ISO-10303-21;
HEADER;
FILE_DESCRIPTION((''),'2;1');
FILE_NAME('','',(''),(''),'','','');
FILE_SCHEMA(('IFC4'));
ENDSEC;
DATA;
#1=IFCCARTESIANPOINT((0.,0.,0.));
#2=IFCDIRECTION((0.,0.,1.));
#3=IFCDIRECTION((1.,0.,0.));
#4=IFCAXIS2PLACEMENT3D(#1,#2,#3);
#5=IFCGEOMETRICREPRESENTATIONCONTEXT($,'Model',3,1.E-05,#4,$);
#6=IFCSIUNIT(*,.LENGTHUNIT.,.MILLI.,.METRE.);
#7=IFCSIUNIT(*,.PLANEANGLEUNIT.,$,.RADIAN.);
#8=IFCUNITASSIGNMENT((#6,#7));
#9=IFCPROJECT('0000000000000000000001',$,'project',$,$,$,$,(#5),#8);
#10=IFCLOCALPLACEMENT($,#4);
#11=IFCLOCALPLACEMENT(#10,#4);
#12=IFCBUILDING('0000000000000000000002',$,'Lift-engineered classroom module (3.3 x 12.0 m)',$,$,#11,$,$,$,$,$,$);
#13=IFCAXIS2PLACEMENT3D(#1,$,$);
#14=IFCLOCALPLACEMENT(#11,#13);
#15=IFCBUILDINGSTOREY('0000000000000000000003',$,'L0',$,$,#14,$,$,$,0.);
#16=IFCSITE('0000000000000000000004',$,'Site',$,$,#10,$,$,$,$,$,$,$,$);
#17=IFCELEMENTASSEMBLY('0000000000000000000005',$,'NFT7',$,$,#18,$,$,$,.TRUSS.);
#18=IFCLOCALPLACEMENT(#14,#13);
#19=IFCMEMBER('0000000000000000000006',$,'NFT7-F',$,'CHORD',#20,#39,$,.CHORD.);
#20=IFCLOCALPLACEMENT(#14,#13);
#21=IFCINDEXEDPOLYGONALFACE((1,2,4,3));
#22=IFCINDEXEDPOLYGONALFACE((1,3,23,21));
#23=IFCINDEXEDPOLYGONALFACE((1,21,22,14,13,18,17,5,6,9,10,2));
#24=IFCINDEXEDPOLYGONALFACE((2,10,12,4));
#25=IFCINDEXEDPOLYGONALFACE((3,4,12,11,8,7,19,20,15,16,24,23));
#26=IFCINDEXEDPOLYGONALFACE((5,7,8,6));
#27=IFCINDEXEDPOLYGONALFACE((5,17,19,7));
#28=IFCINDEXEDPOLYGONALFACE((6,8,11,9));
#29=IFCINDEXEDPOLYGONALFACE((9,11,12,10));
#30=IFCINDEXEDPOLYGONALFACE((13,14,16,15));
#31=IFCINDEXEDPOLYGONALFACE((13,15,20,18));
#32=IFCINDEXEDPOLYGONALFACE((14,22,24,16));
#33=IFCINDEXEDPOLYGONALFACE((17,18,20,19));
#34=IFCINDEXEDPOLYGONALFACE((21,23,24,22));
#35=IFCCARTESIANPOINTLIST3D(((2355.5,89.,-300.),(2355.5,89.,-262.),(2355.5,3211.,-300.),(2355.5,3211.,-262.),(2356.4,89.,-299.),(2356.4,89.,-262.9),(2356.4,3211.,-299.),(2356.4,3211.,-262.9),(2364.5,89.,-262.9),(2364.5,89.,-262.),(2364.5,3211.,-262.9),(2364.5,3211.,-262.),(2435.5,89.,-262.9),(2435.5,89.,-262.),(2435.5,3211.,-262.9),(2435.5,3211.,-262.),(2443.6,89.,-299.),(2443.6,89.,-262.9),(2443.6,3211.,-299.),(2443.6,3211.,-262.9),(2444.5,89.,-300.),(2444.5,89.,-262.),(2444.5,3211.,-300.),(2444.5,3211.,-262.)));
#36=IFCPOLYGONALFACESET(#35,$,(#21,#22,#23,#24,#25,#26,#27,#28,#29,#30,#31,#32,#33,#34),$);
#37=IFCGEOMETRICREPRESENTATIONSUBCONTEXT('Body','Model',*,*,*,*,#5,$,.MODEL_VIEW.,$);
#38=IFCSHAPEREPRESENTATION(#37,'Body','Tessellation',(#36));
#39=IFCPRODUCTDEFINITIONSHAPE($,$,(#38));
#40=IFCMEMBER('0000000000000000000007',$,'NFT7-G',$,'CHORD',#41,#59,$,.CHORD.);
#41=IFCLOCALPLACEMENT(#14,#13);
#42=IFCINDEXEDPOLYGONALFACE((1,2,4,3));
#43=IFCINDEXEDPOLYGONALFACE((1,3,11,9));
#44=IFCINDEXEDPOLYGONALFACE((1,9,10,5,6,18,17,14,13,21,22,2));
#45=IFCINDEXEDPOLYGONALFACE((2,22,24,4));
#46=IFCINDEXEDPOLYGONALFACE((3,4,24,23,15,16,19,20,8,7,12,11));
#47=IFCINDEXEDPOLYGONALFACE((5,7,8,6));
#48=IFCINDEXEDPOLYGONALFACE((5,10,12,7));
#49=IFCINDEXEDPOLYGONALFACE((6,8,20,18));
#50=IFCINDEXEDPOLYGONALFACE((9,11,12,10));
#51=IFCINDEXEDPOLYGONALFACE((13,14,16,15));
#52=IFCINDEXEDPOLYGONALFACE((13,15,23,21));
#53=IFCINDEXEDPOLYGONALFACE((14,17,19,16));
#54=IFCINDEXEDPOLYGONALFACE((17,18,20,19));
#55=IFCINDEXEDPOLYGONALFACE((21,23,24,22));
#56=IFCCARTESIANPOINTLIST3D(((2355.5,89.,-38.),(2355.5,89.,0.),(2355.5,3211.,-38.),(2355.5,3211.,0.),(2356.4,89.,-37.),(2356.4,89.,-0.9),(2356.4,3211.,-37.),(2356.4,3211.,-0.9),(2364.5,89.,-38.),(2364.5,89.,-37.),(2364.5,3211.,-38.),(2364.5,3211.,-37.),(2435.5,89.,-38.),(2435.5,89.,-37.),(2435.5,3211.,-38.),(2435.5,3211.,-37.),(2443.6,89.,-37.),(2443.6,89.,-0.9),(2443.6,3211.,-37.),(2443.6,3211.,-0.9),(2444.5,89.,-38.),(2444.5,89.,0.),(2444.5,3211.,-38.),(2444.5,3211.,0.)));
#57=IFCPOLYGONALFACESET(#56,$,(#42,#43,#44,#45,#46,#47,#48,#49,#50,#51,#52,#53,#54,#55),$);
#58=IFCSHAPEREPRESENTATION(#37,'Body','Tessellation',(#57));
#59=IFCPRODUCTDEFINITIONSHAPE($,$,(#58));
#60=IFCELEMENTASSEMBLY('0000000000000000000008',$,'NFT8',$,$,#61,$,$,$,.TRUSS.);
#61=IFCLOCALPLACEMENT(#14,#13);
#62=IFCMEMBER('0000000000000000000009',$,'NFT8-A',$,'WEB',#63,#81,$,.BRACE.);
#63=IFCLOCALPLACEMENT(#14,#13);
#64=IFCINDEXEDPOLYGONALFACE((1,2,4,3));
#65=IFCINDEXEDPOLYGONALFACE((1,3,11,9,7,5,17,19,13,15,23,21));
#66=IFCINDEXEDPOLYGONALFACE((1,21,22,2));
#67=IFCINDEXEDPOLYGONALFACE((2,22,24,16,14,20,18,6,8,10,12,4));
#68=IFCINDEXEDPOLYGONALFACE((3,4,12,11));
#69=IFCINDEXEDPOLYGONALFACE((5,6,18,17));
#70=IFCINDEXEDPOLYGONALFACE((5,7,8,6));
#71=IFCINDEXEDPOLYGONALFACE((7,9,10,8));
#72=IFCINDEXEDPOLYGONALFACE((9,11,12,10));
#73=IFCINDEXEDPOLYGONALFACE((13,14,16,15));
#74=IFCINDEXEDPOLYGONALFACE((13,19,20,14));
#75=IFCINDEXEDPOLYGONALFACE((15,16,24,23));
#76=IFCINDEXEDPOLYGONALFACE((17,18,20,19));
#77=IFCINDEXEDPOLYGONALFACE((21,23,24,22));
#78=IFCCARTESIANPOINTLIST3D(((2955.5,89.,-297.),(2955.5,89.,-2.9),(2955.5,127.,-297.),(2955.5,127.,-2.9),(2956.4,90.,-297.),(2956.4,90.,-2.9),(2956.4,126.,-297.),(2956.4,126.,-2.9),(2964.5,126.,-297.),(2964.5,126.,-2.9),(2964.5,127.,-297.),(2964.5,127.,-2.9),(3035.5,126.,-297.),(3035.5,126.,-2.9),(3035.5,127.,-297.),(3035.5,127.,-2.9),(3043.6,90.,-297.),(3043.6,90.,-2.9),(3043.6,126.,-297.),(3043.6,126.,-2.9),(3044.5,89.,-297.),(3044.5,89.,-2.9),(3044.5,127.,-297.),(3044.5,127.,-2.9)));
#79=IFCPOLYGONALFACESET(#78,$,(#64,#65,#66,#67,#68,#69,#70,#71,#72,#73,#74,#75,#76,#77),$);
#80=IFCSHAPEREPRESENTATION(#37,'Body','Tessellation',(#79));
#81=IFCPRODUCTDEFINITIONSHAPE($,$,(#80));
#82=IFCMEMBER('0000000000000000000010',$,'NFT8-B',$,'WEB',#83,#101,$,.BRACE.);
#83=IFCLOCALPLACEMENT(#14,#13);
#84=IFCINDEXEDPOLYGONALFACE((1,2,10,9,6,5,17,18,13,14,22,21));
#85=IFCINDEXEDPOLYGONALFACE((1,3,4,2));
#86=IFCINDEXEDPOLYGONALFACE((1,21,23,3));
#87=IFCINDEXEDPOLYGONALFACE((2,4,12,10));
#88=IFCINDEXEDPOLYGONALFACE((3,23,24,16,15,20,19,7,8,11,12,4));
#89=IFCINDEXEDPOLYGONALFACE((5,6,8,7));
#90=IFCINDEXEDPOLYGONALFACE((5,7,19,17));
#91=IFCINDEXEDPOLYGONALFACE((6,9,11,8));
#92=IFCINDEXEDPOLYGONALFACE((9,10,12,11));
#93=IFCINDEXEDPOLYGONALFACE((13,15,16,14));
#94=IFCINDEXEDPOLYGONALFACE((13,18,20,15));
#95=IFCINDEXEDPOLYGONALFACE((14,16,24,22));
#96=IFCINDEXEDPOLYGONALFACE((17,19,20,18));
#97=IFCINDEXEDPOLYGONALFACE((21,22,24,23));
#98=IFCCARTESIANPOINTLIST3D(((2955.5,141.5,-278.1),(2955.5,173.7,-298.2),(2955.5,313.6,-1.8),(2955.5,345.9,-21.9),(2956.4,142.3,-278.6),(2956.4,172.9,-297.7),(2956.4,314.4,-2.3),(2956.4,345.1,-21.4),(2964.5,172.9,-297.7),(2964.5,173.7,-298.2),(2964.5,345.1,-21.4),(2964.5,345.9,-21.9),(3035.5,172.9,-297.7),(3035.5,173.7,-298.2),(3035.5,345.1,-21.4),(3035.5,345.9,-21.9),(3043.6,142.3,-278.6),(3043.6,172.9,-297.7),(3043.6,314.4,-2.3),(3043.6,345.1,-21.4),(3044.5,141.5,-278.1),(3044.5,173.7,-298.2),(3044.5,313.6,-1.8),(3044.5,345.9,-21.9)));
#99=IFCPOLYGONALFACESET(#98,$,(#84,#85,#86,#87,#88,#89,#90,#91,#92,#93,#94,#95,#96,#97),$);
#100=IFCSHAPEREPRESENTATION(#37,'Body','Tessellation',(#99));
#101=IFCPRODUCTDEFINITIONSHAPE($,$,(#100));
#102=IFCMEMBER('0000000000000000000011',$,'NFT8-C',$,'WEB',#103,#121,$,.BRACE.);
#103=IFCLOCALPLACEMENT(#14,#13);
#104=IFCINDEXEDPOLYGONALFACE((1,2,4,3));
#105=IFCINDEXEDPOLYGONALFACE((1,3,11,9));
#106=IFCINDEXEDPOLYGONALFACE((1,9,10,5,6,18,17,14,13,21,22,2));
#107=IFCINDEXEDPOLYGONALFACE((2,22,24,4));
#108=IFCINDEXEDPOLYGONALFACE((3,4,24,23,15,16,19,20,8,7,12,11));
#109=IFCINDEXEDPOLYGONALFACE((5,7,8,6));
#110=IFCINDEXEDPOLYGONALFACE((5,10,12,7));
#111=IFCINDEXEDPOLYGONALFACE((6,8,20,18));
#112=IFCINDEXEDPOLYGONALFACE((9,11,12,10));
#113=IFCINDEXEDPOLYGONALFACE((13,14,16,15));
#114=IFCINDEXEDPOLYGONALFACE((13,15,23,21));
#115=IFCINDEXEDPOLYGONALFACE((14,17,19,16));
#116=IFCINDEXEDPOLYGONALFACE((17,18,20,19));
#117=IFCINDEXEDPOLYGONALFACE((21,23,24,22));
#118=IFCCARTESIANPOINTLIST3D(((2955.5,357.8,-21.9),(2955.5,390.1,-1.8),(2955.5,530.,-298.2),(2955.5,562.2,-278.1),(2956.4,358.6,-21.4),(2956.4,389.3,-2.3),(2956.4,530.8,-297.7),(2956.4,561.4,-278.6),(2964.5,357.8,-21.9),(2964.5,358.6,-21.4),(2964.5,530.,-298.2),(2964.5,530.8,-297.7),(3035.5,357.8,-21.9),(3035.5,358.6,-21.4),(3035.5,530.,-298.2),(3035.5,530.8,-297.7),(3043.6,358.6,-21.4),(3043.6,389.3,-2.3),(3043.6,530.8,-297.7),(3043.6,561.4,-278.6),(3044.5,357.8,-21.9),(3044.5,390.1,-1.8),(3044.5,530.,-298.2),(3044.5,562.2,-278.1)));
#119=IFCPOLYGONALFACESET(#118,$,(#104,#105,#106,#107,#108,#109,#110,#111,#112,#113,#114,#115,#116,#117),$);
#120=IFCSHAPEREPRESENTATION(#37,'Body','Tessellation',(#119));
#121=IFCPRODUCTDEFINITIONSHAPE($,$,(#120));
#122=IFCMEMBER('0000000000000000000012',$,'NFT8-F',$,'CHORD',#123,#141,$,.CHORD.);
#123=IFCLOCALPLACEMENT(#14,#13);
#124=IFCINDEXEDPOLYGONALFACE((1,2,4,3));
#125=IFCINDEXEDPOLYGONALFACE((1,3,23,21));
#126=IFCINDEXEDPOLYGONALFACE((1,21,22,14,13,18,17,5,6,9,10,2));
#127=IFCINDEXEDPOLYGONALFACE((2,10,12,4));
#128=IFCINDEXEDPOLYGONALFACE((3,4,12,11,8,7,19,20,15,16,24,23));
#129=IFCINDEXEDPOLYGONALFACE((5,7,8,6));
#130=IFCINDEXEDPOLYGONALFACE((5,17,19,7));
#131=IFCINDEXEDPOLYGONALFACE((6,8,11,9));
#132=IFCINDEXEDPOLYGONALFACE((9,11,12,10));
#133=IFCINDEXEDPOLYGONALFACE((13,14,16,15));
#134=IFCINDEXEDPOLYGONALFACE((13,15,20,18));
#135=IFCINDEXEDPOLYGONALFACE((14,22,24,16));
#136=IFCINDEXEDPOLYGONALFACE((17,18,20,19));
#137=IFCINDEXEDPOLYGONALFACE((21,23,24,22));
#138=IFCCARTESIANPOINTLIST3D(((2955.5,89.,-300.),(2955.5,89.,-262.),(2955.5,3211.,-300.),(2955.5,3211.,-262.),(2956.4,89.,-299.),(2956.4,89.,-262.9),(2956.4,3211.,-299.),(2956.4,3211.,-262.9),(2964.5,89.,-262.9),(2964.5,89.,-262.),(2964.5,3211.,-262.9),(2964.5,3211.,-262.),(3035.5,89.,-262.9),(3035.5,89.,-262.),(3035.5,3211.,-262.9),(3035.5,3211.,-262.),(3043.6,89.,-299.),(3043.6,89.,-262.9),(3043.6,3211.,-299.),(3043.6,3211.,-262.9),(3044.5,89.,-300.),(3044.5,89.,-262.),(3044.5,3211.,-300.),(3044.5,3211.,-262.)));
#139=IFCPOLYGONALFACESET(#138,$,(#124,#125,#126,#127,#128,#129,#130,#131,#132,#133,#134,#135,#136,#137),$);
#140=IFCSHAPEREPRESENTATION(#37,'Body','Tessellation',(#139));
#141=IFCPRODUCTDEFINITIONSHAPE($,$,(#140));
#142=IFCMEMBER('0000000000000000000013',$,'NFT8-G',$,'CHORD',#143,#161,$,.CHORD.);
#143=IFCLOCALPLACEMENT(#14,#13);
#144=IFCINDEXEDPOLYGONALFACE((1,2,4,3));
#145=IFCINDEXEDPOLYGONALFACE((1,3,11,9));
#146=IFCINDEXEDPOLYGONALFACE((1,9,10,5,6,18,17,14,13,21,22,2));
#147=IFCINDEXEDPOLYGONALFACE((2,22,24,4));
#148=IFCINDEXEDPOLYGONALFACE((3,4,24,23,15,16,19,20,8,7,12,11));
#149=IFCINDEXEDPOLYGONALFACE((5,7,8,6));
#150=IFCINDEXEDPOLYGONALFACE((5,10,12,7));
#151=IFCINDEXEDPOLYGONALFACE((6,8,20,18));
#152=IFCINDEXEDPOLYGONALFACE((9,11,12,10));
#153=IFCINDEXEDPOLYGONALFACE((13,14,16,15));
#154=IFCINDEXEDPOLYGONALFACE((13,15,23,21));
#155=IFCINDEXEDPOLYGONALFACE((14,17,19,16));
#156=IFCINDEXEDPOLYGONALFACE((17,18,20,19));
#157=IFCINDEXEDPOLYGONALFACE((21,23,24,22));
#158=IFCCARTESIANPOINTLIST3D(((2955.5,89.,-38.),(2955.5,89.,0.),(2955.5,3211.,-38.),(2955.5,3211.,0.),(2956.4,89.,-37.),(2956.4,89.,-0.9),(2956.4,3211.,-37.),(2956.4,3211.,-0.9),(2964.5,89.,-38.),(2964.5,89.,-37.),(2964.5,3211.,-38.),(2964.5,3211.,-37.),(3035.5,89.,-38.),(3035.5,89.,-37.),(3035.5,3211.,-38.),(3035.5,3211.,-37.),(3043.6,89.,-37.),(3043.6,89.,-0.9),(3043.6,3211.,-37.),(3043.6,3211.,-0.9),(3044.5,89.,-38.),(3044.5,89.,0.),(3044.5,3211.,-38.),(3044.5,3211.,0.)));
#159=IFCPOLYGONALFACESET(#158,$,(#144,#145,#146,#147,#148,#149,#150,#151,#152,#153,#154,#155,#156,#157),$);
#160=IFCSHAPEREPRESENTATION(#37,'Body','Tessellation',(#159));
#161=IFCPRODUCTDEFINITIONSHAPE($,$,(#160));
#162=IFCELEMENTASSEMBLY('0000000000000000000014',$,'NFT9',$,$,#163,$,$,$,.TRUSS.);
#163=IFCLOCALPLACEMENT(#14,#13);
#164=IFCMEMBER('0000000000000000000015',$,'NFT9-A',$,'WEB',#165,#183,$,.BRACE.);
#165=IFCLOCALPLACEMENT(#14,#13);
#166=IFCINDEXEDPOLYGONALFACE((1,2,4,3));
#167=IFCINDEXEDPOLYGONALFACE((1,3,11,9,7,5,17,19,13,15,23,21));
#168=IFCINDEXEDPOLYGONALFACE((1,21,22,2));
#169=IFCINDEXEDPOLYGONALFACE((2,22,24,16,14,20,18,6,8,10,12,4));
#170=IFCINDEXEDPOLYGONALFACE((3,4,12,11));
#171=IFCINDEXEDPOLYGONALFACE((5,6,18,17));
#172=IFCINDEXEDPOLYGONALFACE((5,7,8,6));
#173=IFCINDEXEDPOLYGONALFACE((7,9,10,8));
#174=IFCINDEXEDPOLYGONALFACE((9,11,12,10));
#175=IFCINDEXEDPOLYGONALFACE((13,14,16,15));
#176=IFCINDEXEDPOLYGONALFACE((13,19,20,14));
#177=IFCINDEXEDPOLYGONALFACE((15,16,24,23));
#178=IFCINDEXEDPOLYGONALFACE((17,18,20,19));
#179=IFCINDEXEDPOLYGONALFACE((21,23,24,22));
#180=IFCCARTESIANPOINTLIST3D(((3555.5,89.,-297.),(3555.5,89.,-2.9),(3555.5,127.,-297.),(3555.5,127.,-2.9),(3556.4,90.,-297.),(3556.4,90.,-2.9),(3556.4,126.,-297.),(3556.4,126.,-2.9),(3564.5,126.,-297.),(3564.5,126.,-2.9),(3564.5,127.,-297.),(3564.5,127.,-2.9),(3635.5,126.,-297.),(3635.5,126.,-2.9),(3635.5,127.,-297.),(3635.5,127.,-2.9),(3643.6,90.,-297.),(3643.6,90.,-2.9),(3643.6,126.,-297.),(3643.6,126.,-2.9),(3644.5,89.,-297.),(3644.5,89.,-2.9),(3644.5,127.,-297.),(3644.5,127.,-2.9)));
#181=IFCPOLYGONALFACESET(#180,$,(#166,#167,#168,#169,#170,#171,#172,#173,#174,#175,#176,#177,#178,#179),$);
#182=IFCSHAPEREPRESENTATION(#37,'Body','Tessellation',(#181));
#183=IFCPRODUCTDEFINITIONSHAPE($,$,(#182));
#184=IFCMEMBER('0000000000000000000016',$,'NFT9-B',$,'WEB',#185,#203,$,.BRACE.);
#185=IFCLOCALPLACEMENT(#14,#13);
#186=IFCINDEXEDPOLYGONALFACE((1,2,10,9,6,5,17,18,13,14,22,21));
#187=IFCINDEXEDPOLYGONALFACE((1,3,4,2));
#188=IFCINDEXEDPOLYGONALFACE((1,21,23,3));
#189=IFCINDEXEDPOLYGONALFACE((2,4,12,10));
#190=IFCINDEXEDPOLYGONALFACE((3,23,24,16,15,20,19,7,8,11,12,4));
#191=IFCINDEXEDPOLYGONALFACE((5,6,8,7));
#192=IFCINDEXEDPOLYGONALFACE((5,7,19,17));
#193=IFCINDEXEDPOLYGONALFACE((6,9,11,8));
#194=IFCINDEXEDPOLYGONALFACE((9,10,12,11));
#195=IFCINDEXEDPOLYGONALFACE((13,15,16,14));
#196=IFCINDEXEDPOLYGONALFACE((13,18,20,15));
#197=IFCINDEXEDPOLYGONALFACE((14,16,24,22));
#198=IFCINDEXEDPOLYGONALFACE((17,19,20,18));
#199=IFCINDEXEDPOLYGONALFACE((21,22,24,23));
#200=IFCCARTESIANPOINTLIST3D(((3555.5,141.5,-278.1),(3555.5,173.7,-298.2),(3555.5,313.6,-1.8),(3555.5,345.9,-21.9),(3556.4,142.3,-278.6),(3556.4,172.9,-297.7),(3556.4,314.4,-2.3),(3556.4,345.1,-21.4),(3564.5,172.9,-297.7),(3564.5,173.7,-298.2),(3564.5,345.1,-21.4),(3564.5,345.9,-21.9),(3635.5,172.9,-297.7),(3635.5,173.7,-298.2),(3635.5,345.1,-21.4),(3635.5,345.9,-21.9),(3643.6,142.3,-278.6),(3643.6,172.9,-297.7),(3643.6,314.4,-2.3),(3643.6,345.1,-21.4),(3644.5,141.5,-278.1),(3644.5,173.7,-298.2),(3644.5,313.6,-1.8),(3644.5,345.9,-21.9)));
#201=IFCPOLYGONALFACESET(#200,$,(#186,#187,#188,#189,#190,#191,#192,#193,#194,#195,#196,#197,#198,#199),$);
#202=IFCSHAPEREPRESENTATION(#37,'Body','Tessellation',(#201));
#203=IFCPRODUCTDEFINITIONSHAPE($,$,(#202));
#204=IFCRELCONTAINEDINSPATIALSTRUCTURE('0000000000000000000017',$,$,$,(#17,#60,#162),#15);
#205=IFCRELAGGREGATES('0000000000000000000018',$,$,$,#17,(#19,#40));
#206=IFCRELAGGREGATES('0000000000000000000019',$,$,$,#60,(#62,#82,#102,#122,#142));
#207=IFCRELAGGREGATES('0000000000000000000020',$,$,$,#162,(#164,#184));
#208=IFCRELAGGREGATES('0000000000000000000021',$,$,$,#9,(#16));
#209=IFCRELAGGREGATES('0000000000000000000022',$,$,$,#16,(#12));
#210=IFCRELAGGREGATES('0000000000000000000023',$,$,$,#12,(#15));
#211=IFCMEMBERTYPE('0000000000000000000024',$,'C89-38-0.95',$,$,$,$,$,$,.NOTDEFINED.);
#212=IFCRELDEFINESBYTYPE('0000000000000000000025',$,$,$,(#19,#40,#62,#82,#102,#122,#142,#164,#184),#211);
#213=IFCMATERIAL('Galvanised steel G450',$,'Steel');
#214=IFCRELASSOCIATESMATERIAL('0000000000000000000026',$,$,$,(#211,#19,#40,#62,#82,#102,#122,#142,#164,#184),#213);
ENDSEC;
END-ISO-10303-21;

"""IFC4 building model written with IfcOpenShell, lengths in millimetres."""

from ifc_helpers import new_model, si_unit, frame, origin, origin_with_axes, origin_2d, place, context, subcontext, project, spatial, c_section, extrude, material, material_profile, profile_set, profile_usage, type_object, element, aggregate, save


model = new_model("IFC4")

# Units and contexts
model_context = context("Model", 3, precision=1e-05, world=origin_with_axes())
body_context = subcontext(model_context, "Body", "Model", "MODEL_VIEW")
ifc_project = project(units=[si_unit("LENGTHUNIT", "METRE", prefix="MILLI"), si_unit("PLANEANGLEUNIT", "RADIAN")], contexts=[model_context])

# Site, building, storey
site_placement = place(None, origin_with_axes())
site = spatial("IfcSite", under=ifc_project, at=site_placement, Name="Site")
building_placement = place(site_placement, origin_with_axes())
building = spatial("IfcBuilding", under=site, at=building_placement, Name="Lift-engineered classroom module (3.3 x 12.0 m)")
storey_placement = place(building_placement, origin())
storey = spatial("IfcBuildingStorey", under=building, at=storey_placement, Name="L0", Elevation=0.0)

# Element assemblies, members
assembly_1_placement = place(storey_placement, frame((2400.0, 89.0, -300.0)))
assembly_1 = element("IfcElementAssembly", 1, at=assembly_1_placement, inside=storey, Name="NFT7", PredefinedType="TRUSS")
ifc_material = material(Name="Galvanised steel G450", Category="Steel")
ifc_material_profile_1 = material_profile(ifc_material, c_section(Depth=89.0, Width=38.0, WallThickness=0.9, Girth=9.0, at=origin_2d()), Name="C89-38-0.95")
ifc_profile_set_1 = profile_set([ifc_material_profile_1], Name="C89-38-0.95")
ifc_profile_usage_1 = profile_usage(ifc_profile_set_1)
member_type_1 = type_object("IfcMemberType", Name="C89-38-0.95", PredefinedType="NOTDEFINED", material=ifc_profile_set_1)
member_1_placement = place(assembly_1_placement, frame((0.0, 0.0, 19.0), z_axis=(0.0, 1.0, 0.0), x_axis=(0.0, 0.0, 1.0)))
member_1 = element("IfcMember", 2, at=member_1_placement, type_object=member_type_1, material=ifc_profile_usage_1, Name="NFT7-F", ObjectType="CHORD", PredefinedType="CHORD", context=body_context, shape_type="SweptSolid", body=[
    extrude(c_section(Depth=89.0, Width=38.0, WallThickness=0.9, Girth=9.0, at=origin_2d()), origin(), (0.0, 0.0, 1.0), 3122.0),
])
member_2_placement = place(assembly_1_placement, frame((0.0, 0.0, 281.0), z_axis=(0.0, 1.0, 0.0), x_axis=(0.0, 0.0, -1.0)))
member_2 = element("IfcMember", 3, at=member_2_placement, type_object=member_type_1, material=ifc_profile_usage_1, Name="NFT7-G", ObjectType="CHORD", PredefinedType="CHORD", context=body_context, shape_type="SweptSolid", body=[
    extrude(c_section(Depth=89.0, Width=38.0, WallThickness=0.9, Girth=9.0, at=origin_2d()), origin(), (0.0, 0.0, 1.0), 3122.0),
])
aggregate(assembly_1, [member_1, member_2])
assembly_2_placement = place(storey_placement, frame((3000.0, 89.0, -300.0)))
assembly_2 = element("IfcElementAssembly", 4, at=assembly_2_placement, inside=storey, Name="NFT8", PredefinedType="TRUSS")
member_3_placement = place(assembly_2_placement, frame((0.0, 19.0, 2.9), z_axis=(0.0, 0.0, 1.0), x_axis=(0.0, 1.0, 0.0)))
member_3 = element("IfcMember", 5, at=member_3_placement, type_object=member_type_1, material=ifc_profile_usage_1, Name="NFT8-A", ObjectType="WEB", PredefinedType="BRACE", context=body_context, shape_type="SweptSolid", body=[
    extrude(c_section(Depth=89.0, Width=38.0, WallThickness=0.9, Girth=9.0, at=origin_2d()), origin(), (0.0, 0.0, 1.0), 294.1),
])
member_4_placement = place(assembly_2_placement, frame((0.0, 68.6, 11.8), z_axis=(0.0, 0.528797, 0.848748), x_axis=(0.0, 0.848748, -0.528797)))
member_4 = element("IfcMember", 6, at=member_4_placement, type_object=member_type_1, material=ifc_profile_usage_1, Name="NFT8-B", ObjectType="WEB", PredefinedType="BRACE", context=body_context, shape_type="SweptSolid", body=[
    extrude(c_section(Depth=89.0, Width=38.0, WallThickness=0.9, Girth=9.0, at=origin_2d()), origin(), (0.0, 0.0, 1.0), 325.6),
])
member_5_placement = place(assembly_2_placement, frame((0.0, 457.1, 11.8), z_axis=(0.0, -0.528797, 0.848748), x_axis=(0.0, -0.848748, -0.528797)))
member_5 = element("IfcMember", 7, at=member_5_placement, type_object=member_type_1, material=ifc_profile_usage_1, Name="NFT8-C", ObjectType="WEB", PredefinedType="BRACE", context=body_context, shape_type="SweptSolid", body=[
    extrude(c_section(Depth=89.0, Width=38.0, WallThickness=0.9, Girth=9.0, at=origin_2d()), origin(), (0.0, 0.0, 1.0), 325.6),
])
member_6_placement = place(assembly_2_placement, frame((0.0, 0.0, 19.0), z_axis=(0.0, 1.0, 0.0), x_axis=(0.0, 0.0, 1.0)))
member_6 = element("IfcMember", 8, at=member_6_placement, type_object=member_type_1, material=ifc_profile_usage_1, Name="NFT8-F", ObjectType="CHORD", PredefinedType="CHORD", context=body_context, shape_type="SweptSolid", body=[
    extrude(c_section(Depth=89.0, Width=38.0, WallThickness=0.9, Girth=9.0, at=origin_2d()), origin(), (0.0, 0.0, 1.0), 3122.0),
])
member_7_placement = place(assembly_2_placement, frame((0.0, 0.0, 281.0), z_axis=(0.0, 1.0, 0.0), x_axis=(0.0, 0.0, -1.0)))
member_7 = element("IfcMember", 9, at=member_7_placement, type_object=member_type_1, material=ifc_profile_usage_1, Name="NFT8-G", ObjectType="CHORD", PredefinedType="CHORD", context=body_context, shape_type="SweptSolid", body=[
    extrude(c_section(Depth=89.0, Width=38.0, WallThickness=0.9, Girth=9.0, at=origin_2d()), origin(), (0.0, 0.0, 1.0), 3122.0),
])
aggregate(assembly_2, [member_3, member_4, member_5, member_6, member_7])
assembly_3_placement = place(storey_placement, frame((3600.0, 89.0, -300.0)))
assembly_3 = element("IfcElementAssembly", 10, at=assembly_3_placement, inside=storey, Name="NFT9", PredefinedType="TRUSS")
member_8_placement = place(assembly_3_placement, frame((0.0, 19.0, 2.9), z_axis=(0.0, 0.0, 1.0), x_axis=(0.0, 1.0, 0.0)))
member_8 = element("IfcMember", 11, at=member_8_placement, type_object=member_type_1, material=ifc_profile_usage_1, Name="NFT9-A", ObjectType="WEB", PredefinedType="BRACE", context=body_context, shape_type="SweptSolid", body=[
    extrude(c_section(Depth=89.0, Width=38.0, WallThickness=0.9, Girth=9.0, at=origin_2d()), origin(), (0.0, 0.0, 1.0), 294.1),
])
member_9_placement = place(assembly_3_placement, frame((0.0, 68.6, 11.8), z_axis=(0.0, 0.528797, 0.848748), x_axis=(0.0, 0.848748, -0.528797)))
member_9 = element("IfcMember", 12, at=member_9_placement, type_object=member_type_1, material=ifc_profile_usage_1, Name="NFT9-B", ObjectType="WEB", PredefinedType="BRACE", context=body_context, shape_type="SweptSolid", body=[
    extrude(c_section(Depth=89.0, Width=38.0, WallThickness=0.9, Girth=9.0, at=origin_2d()), origin(), (0.0, 0.0, 1.0), 325.6),
])
aggregate(assembly_3, [member_8, member_9])

save(model, "model.ifc")
